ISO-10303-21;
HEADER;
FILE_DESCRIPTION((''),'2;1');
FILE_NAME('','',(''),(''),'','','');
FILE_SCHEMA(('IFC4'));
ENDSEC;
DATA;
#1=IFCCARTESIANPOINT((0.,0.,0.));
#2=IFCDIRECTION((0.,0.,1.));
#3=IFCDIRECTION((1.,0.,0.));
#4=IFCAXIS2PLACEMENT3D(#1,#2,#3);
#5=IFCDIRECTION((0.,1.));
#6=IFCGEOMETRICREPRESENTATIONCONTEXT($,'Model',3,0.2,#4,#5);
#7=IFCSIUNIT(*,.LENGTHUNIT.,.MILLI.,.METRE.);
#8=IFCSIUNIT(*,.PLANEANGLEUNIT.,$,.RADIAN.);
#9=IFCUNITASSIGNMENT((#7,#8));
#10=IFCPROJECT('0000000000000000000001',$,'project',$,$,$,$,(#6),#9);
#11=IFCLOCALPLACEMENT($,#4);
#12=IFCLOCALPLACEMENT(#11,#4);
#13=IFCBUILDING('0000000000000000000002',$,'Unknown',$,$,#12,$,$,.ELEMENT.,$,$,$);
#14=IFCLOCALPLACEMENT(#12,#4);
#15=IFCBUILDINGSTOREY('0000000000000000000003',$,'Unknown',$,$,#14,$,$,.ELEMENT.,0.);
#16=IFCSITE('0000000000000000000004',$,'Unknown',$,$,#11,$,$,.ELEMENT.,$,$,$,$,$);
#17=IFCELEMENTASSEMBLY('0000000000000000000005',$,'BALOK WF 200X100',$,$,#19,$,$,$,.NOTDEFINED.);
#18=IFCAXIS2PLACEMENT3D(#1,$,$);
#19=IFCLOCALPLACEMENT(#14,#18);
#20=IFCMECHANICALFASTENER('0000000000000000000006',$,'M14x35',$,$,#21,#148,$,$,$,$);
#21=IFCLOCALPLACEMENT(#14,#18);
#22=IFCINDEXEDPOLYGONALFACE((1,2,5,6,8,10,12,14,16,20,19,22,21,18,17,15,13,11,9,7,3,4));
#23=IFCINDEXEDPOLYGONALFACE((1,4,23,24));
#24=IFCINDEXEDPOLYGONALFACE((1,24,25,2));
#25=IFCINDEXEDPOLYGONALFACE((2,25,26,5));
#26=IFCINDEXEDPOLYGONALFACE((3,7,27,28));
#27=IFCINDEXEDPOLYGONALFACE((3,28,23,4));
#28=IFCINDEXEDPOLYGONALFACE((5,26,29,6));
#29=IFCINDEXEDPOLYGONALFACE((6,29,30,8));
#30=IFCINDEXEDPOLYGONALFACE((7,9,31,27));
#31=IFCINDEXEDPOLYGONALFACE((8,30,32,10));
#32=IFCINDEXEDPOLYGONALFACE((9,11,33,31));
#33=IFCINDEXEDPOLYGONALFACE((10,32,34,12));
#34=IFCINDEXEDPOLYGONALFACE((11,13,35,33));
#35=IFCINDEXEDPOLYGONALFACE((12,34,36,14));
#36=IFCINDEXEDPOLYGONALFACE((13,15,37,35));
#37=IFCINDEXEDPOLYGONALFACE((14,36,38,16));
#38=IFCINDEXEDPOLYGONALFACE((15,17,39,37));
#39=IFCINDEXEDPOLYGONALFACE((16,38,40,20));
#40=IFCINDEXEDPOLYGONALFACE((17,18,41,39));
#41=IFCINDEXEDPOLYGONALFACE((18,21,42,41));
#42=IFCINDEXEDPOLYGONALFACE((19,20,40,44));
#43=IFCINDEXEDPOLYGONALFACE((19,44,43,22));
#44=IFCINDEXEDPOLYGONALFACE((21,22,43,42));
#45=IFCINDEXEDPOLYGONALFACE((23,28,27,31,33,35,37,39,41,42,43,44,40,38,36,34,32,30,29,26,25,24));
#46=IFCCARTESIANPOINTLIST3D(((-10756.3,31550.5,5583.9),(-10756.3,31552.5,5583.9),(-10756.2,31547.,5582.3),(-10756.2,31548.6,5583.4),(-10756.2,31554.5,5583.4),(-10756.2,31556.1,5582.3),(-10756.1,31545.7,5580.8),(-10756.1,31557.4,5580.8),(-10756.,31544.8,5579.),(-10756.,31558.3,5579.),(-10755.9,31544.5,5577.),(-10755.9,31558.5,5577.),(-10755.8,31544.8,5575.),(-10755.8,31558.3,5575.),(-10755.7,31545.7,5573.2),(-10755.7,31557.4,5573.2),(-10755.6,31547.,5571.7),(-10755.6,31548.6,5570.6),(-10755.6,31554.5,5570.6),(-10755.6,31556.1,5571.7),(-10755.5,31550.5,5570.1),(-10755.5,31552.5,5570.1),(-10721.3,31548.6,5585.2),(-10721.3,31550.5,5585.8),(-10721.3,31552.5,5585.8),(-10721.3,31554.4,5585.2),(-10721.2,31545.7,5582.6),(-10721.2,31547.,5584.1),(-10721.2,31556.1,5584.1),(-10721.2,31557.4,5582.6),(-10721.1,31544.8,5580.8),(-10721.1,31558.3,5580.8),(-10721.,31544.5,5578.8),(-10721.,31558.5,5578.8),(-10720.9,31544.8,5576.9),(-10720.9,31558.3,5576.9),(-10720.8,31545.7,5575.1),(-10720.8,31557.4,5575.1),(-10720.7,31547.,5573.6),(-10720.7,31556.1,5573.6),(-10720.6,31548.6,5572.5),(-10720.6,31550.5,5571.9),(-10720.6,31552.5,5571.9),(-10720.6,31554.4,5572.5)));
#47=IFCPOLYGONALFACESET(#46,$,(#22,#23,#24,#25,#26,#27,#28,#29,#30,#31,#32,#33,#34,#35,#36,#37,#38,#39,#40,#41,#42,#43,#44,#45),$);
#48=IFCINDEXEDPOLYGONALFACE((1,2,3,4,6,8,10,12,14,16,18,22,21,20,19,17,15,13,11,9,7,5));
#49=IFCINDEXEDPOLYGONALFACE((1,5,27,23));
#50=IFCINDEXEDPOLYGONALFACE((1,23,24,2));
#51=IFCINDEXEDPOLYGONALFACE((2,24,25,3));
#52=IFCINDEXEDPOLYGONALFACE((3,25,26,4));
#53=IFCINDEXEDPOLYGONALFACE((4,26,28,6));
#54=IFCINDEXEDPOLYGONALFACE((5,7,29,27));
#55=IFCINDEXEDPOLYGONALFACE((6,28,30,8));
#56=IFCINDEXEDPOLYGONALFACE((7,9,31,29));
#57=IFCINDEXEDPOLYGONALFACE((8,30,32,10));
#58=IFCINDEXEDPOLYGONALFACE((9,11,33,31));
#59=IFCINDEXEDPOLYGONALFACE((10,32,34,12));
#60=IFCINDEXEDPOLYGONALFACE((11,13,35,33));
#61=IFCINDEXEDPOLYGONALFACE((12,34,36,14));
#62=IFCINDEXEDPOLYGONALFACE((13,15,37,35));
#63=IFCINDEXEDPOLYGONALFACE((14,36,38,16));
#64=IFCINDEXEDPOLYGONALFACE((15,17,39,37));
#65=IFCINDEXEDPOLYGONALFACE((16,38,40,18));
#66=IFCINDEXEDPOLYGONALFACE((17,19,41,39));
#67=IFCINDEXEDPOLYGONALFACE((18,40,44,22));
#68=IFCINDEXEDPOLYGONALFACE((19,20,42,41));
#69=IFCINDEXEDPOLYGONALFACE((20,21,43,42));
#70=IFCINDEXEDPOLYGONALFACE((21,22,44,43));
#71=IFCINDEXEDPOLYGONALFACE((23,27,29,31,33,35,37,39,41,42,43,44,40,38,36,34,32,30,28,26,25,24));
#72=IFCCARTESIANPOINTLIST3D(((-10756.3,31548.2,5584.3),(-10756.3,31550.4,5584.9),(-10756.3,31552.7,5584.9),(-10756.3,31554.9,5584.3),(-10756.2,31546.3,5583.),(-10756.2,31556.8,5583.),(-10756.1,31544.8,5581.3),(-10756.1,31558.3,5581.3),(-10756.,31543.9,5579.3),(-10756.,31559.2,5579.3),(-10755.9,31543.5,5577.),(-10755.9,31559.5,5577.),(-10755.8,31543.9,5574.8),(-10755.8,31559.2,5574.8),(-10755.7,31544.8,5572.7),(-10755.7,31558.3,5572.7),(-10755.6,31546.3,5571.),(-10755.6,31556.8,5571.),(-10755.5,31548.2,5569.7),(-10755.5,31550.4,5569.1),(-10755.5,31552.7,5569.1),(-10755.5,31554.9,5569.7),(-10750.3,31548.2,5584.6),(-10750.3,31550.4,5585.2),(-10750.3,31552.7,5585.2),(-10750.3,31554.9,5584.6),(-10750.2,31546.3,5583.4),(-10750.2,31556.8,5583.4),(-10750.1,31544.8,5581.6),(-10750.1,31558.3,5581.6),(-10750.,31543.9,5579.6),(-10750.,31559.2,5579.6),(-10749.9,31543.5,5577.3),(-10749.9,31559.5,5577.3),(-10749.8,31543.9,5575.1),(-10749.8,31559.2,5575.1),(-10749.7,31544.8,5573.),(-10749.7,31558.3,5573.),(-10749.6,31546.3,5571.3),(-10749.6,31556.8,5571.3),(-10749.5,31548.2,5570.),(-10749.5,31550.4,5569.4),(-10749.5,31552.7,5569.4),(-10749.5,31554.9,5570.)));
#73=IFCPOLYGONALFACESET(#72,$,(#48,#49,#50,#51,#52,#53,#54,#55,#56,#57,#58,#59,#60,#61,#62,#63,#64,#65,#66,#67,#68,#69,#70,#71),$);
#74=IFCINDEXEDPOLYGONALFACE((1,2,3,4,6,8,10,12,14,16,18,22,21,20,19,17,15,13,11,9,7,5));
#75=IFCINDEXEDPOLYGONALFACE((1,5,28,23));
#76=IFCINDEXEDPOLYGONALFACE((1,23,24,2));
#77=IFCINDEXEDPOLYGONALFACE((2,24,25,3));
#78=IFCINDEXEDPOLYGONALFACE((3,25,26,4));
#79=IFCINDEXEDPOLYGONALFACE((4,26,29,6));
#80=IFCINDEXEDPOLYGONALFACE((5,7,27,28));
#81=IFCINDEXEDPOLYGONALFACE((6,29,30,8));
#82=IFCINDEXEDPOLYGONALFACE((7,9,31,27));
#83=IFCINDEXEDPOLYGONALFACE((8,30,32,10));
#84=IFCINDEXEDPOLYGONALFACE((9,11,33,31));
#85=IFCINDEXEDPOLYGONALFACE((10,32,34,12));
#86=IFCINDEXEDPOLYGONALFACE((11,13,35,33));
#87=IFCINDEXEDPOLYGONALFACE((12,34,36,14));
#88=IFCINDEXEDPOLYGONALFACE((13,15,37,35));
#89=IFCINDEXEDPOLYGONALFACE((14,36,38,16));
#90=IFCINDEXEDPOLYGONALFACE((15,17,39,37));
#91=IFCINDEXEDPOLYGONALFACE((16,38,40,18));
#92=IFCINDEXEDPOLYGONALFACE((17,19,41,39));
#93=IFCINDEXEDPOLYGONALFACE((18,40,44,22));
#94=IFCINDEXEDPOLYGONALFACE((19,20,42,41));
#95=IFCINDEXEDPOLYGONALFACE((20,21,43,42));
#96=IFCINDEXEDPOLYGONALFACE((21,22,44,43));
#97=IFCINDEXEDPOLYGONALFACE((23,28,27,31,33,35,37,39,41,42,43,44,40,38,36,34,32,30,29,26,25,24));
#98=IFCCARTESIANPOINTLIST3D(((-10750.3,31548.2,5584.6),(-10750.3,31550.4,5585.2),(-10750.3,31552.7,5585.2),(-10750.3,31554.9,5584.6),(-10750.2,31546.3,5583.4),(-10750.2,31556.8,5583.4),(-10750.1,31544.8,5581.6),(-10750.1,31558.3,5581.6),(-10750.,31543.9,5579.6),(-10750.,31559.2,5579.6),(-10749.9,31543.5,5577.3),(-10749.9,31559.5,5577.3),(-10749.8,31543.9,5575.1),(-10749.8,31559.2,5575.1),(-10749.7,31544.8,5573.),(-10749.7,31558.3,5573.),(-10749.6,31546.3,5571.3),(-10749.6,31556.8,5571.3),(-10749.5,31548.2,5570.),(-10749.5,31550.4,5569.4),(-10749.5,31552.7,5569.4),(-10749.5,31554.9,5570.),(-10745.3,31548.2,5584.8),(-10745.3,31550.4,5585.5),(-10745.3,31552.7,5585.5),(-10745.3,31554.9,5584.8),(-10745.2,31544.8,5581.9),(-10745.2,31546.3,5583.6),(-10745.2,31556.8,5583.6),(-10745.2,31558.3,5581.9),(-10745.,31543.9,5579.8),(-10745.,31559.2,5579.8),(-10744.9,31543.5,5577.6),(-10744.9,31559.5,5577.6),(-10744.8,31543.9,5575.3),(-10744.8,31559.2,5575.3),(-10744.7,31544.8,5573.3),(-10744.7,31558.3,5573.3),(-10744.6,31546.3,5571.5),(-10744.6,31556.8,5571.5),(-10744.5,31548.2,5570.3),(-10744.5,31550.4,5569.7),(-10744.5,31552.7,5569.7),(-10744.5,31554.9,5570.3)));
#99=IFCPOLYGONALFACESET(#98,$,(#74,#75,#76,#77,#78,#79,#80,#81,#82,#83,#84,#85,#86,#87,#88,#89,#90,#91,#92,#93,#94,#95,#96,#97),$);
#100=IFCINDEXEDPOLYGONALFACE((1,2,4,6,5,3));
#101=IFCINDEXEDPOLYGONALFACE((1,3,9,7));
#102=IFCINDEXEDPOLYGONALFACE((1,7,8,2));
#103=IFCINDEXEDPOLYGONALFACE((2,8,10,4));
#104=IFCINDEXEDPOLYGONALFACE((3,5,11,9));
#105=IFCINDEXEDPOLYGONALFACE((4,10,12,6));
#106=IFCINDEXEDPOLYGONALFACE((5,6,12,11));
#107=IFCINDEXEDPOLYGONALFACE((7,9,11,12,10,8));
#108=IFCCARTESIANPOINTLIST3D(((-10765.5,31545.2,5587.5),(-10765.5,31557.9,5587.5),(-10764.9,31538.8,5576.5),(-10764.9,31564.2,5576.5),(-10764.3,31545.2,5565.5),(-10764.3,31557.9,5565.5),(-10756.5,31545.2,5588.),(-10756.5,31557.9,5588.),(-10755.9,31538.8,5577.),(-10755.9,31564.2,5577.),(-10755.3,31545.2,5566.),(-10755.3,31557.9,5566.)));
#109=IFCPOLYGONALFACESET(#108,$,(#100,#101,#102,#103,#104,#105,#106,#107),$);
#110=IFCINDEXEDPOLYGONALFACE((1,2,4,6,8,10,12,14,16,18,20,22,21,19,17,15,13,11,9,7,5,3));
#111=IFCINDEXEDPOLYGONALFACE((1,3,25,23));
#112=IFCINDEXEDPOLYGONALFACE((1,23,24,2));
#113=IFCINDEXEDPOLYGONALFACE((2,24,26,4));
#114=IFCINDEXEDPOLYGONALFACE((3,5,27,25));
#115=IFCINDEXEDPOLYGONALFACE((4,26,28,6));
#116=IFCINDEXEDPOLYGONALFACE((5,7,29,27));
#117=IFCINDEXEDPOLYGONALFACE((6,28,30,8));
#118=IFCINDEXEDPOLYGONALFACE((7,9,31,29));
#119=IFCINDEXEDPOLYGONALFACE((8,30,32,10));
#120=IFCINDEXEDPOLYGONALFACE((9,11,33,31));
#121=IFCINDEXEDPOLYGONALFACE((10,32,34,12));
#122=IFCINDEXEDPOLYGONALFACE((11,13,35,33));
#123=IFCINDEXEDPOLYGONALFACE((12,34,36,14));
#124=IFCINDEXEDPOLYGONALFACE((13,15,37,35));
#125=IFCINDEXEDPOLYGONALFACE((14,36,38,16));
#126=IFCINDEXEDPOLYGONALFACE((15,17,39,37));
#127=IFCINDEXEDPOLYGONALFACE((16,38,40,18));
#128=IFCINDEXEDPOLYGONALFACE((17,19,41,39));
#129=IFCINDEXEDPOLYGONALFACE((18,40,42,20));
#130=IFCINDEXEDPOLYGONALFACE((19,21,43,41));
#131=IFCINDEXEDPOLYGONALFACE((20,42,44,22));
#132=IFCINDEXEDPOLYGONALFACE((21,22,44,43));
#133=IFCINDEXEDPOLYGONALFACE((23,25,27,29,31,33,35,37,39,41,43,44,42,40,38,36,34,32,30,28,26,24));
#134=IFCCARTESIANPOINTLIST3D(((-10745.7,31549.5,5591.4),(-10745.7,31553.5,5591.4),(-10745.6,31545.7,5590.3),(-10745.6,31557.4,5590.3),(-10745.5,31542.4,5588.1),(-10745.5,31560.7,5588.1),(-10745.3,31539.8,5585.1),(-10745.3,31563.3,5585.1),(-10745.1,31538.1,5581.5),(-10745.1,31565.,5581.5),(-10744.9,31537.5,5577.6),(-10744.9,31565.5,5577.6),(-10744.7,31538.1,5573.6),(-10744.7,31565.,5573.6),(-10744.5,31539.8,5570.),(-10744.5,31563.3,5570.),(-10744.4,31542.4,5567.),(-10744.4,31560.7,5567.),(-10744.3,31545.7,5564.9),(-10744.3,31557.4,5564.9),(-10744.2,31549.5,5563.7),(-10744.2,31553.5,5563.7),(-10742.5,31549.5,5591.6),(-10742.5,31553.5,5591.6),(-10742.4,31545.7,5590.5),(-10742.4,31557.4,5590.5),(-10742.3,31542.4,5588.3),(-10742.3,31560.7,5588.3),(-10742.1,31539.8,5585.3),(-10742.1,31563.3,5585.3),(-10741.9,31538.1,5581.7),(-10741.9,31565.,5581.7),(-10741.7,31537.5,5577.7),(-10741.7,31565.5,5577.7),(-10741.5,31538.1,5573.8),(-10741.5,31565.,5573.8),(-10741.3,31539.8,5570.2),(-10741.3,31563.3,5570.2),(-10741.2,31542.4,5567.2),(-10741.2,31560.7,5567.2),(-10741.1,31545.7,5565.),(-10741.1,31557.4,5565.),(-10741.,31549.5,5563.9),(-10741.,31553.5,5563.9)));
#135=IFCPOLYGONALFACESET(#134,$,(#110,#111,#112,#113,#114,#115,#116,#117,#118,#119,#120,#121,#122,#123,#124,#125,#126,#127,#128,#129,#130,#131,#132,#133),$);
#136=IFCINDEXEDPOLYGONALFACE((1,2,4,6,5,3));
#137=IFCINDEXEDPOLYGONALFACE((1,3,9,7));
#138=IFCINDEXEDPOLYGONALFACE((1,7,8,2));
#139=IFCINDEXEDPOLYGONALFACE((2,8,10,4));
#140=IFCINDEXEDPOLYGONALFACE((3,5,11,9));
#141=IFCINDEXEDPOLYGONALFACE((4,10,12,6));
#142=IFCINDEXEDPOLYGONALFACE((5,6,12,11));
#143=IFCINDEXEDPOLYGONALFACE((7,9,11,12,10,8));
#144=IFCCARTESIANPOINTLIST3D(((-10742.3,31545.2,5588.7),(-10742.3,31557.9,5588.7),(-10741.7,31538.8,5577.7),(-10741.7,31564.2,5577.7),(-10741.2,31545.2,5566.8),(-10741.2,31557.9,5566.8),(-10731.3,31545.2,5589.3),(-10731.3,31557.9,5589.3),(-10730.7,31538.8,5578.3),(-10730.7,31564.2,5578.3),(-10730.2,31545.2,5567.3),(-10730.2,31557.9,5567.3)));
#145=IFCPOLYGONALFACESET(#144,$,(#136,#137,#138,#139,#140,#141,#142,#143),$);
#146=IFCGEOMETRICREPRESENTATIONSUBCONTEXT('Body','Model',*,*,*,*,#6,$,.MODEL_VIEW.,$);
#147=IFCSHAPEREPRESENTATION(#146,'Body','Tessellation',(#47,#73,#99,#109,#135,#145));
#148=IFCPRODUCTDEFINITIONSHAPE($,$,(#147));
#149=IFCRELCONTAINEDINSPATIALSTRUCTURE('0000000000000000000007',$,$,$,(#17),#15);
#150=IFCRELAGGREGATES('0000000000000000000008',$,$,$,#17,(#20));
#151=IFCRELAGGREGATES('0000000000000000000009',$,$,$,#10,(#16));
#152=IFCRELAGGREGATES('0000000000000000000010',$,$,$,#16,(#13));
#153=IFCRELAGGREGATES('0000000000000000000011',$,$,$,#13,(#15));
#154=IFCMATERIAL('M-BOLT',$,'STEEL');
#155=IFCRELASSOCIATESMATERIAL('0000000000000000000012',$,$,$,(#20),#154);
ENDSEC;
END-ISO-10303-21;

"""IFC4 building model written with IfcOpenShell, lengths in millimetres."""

from ifc_helpers import new_model, si_unit, direction, frame, origin_with_axes, place, context, subcontext, project, spatial, line, arc, indexed_curve, outline, extrude, source, transform, mapped, material, element, aggregate, save


model = new_model("IFC4")

# Units and contexts
model_context = context("Model", 3, precision=0.2, world=origin_with_axes(), true_north=direction((0.0, 1.0)))
body_context = subcontext(model_context, "Body", "Model", "MODEL_VIEW")
ifc_project = project(units=[si_unit("LENGTHUNIT", "METRE", prefix="MILLI"), si_unit("PLANEANGLEUNIT", "RADIAN")], contexts=[model_context])

# Site, building, storey
site_placement = place(None, origin_with_axes())
site = spatial("IfcSite", under=ifc_project, at=site_placement, Name="Unknown", CompositionType="ELEMENT")
building_placement = place(site_placement, origin_with_axes())
building = spatial("IfcBuilding", under=site, at=building_placement, Name="Unknown", CompositionType="ELEMENT")
storey_placement = place(building_placement, origin_with_axes())
storey = spatial("IfcBuildingStorey", under=building, at=storey_placement, Name="Unknown", CompositionType="ELEMENT", Elevation=0.0)

# Element assembly
assembly_1_placement = place(storey_placement, frame((-7044.1, 31466.5, 5721.5), z_axis=(0.0, 1.0, 0.0), x_axis=(-0.99863, 0.0, -0.052336)))
assembly_1 = element("IfcElementAssembly", 1, at=assembly_1_placement, inside=storey, Name="BALOK WF 200X100", PredefinedType="NOTDEFINED")

# Mechanical fastener
ifc_material_1 = material(Name="M-BOLT", Category="STEEL")
shared_shape_1 = source(origin_with_axes(), body_context, "Body", "SweptSolid", [
    extrude(outline(indexed_curve([(7.0, 0.0), (0.0, 7.0), (-7.0, 0.0), (0.0, -7.0)], segments=[arc(1, 2, 3), arc(3, 4, 1)])), frame((0.0, 0.0, 0.0), z_axis=(0.0, 0.0, -1.0), x_axis=(0.0, 1.0, 0.0)), (0.0, 0.0, 1.0), 35.0),
    extrude(outline(indexed_curve([(8.0, 0.0), (0.0, 8.0), (-8.0, 0.0), (0.0, -8.0)], segments=[arc(1, 2, 3), arc(3, 4, 1)])), frame((0.0, 0.0, 0.0), z_axis=(0.0, 0.0, -1.0), x_axis=(0.0, 1.0, 0.0)), (0.0, 0.0, 1.0), 6.0),
    extrude(outline(indexed_curve([(8.0, 0.0), (0.0, 8.0), (-8.0, 0.0), (0.0, -8.0)], segments=[arc(1, 2, 3), arc(3, 4, 1)])), frame((0.0, 0.0, -6.0), z_axis=(0.0, 0.0, -1.0), x_axis=(0.0, 1.0, 0.0)), (0.0, 0.0, 1.0), 5.0),
    extrude(outline(indexed_curve([(12.7, 0.0), (6.4, 11.0), (-6.4, 11.0), (-12.7, 0.0), (-6.4, -11.0), (6.4, -11.0)], segments=[line(1, 2, 3, 4, 5, 6, 1)])), frame((0.0, 0.0, 9.0), z_axis=(0.0, 0.0, -1.0), x_axis=(0.0, 1.0, 0.0)), (0.0, 0.0, 1.0), 9.0),
    extrude(outline(indexed_curve([(14.0, 0.0), (0.0, 14.0), (-14.0, 0.0), (0.0, -14.0)], segments=[arc(1, 2, 3), arc(3, 4, 1)])), frame((0.0, 0.0, -11.0), z_axis=(0.0, 0.0, -1.0), x_axis=(0.0, 1.0, 0.0)), (0.0, 0.0, 1.0), 3.2),
    extrude(outline(indexed_curve([(12.7, 0.0), (6.4, 11.0), (-6.4, 11.0), (-12.7, 0.0), (-6.4, -11.0), (6.4, -11.0)], segments=[line(1, 2, 3, 4, 5, 6, 1)])), frame((0.0, 0.0, -14.2), z_axis=(0.0, 0.0, -1.0), x_axis=(0.0, 1.0, 0.0)), (0.0, 0.0, 1.0), 11.0),
])
mechanical_fastener_1_placement = place(assembly_1_placement, frame((3714.2, 50.0, 85.0), z_axis=(1.0, 0.0, 0.000006), x_axis=(0.0, -1.0, 0.0)))
mechanical_fastener_1 = element("IfcMechanicalFastener", 2, at=mechanical_fastener_1_placement, material=ifc_material_1, Name="M14x35", context=body_context, shape_type="MappedRepresentation", body=[
    mapped(shared_shape_1, transform((0.0, 0.0, 0.0))),
])

aggregate(assembly_1, [mechanical_fastener_1])

save(model, "model.ifc")
